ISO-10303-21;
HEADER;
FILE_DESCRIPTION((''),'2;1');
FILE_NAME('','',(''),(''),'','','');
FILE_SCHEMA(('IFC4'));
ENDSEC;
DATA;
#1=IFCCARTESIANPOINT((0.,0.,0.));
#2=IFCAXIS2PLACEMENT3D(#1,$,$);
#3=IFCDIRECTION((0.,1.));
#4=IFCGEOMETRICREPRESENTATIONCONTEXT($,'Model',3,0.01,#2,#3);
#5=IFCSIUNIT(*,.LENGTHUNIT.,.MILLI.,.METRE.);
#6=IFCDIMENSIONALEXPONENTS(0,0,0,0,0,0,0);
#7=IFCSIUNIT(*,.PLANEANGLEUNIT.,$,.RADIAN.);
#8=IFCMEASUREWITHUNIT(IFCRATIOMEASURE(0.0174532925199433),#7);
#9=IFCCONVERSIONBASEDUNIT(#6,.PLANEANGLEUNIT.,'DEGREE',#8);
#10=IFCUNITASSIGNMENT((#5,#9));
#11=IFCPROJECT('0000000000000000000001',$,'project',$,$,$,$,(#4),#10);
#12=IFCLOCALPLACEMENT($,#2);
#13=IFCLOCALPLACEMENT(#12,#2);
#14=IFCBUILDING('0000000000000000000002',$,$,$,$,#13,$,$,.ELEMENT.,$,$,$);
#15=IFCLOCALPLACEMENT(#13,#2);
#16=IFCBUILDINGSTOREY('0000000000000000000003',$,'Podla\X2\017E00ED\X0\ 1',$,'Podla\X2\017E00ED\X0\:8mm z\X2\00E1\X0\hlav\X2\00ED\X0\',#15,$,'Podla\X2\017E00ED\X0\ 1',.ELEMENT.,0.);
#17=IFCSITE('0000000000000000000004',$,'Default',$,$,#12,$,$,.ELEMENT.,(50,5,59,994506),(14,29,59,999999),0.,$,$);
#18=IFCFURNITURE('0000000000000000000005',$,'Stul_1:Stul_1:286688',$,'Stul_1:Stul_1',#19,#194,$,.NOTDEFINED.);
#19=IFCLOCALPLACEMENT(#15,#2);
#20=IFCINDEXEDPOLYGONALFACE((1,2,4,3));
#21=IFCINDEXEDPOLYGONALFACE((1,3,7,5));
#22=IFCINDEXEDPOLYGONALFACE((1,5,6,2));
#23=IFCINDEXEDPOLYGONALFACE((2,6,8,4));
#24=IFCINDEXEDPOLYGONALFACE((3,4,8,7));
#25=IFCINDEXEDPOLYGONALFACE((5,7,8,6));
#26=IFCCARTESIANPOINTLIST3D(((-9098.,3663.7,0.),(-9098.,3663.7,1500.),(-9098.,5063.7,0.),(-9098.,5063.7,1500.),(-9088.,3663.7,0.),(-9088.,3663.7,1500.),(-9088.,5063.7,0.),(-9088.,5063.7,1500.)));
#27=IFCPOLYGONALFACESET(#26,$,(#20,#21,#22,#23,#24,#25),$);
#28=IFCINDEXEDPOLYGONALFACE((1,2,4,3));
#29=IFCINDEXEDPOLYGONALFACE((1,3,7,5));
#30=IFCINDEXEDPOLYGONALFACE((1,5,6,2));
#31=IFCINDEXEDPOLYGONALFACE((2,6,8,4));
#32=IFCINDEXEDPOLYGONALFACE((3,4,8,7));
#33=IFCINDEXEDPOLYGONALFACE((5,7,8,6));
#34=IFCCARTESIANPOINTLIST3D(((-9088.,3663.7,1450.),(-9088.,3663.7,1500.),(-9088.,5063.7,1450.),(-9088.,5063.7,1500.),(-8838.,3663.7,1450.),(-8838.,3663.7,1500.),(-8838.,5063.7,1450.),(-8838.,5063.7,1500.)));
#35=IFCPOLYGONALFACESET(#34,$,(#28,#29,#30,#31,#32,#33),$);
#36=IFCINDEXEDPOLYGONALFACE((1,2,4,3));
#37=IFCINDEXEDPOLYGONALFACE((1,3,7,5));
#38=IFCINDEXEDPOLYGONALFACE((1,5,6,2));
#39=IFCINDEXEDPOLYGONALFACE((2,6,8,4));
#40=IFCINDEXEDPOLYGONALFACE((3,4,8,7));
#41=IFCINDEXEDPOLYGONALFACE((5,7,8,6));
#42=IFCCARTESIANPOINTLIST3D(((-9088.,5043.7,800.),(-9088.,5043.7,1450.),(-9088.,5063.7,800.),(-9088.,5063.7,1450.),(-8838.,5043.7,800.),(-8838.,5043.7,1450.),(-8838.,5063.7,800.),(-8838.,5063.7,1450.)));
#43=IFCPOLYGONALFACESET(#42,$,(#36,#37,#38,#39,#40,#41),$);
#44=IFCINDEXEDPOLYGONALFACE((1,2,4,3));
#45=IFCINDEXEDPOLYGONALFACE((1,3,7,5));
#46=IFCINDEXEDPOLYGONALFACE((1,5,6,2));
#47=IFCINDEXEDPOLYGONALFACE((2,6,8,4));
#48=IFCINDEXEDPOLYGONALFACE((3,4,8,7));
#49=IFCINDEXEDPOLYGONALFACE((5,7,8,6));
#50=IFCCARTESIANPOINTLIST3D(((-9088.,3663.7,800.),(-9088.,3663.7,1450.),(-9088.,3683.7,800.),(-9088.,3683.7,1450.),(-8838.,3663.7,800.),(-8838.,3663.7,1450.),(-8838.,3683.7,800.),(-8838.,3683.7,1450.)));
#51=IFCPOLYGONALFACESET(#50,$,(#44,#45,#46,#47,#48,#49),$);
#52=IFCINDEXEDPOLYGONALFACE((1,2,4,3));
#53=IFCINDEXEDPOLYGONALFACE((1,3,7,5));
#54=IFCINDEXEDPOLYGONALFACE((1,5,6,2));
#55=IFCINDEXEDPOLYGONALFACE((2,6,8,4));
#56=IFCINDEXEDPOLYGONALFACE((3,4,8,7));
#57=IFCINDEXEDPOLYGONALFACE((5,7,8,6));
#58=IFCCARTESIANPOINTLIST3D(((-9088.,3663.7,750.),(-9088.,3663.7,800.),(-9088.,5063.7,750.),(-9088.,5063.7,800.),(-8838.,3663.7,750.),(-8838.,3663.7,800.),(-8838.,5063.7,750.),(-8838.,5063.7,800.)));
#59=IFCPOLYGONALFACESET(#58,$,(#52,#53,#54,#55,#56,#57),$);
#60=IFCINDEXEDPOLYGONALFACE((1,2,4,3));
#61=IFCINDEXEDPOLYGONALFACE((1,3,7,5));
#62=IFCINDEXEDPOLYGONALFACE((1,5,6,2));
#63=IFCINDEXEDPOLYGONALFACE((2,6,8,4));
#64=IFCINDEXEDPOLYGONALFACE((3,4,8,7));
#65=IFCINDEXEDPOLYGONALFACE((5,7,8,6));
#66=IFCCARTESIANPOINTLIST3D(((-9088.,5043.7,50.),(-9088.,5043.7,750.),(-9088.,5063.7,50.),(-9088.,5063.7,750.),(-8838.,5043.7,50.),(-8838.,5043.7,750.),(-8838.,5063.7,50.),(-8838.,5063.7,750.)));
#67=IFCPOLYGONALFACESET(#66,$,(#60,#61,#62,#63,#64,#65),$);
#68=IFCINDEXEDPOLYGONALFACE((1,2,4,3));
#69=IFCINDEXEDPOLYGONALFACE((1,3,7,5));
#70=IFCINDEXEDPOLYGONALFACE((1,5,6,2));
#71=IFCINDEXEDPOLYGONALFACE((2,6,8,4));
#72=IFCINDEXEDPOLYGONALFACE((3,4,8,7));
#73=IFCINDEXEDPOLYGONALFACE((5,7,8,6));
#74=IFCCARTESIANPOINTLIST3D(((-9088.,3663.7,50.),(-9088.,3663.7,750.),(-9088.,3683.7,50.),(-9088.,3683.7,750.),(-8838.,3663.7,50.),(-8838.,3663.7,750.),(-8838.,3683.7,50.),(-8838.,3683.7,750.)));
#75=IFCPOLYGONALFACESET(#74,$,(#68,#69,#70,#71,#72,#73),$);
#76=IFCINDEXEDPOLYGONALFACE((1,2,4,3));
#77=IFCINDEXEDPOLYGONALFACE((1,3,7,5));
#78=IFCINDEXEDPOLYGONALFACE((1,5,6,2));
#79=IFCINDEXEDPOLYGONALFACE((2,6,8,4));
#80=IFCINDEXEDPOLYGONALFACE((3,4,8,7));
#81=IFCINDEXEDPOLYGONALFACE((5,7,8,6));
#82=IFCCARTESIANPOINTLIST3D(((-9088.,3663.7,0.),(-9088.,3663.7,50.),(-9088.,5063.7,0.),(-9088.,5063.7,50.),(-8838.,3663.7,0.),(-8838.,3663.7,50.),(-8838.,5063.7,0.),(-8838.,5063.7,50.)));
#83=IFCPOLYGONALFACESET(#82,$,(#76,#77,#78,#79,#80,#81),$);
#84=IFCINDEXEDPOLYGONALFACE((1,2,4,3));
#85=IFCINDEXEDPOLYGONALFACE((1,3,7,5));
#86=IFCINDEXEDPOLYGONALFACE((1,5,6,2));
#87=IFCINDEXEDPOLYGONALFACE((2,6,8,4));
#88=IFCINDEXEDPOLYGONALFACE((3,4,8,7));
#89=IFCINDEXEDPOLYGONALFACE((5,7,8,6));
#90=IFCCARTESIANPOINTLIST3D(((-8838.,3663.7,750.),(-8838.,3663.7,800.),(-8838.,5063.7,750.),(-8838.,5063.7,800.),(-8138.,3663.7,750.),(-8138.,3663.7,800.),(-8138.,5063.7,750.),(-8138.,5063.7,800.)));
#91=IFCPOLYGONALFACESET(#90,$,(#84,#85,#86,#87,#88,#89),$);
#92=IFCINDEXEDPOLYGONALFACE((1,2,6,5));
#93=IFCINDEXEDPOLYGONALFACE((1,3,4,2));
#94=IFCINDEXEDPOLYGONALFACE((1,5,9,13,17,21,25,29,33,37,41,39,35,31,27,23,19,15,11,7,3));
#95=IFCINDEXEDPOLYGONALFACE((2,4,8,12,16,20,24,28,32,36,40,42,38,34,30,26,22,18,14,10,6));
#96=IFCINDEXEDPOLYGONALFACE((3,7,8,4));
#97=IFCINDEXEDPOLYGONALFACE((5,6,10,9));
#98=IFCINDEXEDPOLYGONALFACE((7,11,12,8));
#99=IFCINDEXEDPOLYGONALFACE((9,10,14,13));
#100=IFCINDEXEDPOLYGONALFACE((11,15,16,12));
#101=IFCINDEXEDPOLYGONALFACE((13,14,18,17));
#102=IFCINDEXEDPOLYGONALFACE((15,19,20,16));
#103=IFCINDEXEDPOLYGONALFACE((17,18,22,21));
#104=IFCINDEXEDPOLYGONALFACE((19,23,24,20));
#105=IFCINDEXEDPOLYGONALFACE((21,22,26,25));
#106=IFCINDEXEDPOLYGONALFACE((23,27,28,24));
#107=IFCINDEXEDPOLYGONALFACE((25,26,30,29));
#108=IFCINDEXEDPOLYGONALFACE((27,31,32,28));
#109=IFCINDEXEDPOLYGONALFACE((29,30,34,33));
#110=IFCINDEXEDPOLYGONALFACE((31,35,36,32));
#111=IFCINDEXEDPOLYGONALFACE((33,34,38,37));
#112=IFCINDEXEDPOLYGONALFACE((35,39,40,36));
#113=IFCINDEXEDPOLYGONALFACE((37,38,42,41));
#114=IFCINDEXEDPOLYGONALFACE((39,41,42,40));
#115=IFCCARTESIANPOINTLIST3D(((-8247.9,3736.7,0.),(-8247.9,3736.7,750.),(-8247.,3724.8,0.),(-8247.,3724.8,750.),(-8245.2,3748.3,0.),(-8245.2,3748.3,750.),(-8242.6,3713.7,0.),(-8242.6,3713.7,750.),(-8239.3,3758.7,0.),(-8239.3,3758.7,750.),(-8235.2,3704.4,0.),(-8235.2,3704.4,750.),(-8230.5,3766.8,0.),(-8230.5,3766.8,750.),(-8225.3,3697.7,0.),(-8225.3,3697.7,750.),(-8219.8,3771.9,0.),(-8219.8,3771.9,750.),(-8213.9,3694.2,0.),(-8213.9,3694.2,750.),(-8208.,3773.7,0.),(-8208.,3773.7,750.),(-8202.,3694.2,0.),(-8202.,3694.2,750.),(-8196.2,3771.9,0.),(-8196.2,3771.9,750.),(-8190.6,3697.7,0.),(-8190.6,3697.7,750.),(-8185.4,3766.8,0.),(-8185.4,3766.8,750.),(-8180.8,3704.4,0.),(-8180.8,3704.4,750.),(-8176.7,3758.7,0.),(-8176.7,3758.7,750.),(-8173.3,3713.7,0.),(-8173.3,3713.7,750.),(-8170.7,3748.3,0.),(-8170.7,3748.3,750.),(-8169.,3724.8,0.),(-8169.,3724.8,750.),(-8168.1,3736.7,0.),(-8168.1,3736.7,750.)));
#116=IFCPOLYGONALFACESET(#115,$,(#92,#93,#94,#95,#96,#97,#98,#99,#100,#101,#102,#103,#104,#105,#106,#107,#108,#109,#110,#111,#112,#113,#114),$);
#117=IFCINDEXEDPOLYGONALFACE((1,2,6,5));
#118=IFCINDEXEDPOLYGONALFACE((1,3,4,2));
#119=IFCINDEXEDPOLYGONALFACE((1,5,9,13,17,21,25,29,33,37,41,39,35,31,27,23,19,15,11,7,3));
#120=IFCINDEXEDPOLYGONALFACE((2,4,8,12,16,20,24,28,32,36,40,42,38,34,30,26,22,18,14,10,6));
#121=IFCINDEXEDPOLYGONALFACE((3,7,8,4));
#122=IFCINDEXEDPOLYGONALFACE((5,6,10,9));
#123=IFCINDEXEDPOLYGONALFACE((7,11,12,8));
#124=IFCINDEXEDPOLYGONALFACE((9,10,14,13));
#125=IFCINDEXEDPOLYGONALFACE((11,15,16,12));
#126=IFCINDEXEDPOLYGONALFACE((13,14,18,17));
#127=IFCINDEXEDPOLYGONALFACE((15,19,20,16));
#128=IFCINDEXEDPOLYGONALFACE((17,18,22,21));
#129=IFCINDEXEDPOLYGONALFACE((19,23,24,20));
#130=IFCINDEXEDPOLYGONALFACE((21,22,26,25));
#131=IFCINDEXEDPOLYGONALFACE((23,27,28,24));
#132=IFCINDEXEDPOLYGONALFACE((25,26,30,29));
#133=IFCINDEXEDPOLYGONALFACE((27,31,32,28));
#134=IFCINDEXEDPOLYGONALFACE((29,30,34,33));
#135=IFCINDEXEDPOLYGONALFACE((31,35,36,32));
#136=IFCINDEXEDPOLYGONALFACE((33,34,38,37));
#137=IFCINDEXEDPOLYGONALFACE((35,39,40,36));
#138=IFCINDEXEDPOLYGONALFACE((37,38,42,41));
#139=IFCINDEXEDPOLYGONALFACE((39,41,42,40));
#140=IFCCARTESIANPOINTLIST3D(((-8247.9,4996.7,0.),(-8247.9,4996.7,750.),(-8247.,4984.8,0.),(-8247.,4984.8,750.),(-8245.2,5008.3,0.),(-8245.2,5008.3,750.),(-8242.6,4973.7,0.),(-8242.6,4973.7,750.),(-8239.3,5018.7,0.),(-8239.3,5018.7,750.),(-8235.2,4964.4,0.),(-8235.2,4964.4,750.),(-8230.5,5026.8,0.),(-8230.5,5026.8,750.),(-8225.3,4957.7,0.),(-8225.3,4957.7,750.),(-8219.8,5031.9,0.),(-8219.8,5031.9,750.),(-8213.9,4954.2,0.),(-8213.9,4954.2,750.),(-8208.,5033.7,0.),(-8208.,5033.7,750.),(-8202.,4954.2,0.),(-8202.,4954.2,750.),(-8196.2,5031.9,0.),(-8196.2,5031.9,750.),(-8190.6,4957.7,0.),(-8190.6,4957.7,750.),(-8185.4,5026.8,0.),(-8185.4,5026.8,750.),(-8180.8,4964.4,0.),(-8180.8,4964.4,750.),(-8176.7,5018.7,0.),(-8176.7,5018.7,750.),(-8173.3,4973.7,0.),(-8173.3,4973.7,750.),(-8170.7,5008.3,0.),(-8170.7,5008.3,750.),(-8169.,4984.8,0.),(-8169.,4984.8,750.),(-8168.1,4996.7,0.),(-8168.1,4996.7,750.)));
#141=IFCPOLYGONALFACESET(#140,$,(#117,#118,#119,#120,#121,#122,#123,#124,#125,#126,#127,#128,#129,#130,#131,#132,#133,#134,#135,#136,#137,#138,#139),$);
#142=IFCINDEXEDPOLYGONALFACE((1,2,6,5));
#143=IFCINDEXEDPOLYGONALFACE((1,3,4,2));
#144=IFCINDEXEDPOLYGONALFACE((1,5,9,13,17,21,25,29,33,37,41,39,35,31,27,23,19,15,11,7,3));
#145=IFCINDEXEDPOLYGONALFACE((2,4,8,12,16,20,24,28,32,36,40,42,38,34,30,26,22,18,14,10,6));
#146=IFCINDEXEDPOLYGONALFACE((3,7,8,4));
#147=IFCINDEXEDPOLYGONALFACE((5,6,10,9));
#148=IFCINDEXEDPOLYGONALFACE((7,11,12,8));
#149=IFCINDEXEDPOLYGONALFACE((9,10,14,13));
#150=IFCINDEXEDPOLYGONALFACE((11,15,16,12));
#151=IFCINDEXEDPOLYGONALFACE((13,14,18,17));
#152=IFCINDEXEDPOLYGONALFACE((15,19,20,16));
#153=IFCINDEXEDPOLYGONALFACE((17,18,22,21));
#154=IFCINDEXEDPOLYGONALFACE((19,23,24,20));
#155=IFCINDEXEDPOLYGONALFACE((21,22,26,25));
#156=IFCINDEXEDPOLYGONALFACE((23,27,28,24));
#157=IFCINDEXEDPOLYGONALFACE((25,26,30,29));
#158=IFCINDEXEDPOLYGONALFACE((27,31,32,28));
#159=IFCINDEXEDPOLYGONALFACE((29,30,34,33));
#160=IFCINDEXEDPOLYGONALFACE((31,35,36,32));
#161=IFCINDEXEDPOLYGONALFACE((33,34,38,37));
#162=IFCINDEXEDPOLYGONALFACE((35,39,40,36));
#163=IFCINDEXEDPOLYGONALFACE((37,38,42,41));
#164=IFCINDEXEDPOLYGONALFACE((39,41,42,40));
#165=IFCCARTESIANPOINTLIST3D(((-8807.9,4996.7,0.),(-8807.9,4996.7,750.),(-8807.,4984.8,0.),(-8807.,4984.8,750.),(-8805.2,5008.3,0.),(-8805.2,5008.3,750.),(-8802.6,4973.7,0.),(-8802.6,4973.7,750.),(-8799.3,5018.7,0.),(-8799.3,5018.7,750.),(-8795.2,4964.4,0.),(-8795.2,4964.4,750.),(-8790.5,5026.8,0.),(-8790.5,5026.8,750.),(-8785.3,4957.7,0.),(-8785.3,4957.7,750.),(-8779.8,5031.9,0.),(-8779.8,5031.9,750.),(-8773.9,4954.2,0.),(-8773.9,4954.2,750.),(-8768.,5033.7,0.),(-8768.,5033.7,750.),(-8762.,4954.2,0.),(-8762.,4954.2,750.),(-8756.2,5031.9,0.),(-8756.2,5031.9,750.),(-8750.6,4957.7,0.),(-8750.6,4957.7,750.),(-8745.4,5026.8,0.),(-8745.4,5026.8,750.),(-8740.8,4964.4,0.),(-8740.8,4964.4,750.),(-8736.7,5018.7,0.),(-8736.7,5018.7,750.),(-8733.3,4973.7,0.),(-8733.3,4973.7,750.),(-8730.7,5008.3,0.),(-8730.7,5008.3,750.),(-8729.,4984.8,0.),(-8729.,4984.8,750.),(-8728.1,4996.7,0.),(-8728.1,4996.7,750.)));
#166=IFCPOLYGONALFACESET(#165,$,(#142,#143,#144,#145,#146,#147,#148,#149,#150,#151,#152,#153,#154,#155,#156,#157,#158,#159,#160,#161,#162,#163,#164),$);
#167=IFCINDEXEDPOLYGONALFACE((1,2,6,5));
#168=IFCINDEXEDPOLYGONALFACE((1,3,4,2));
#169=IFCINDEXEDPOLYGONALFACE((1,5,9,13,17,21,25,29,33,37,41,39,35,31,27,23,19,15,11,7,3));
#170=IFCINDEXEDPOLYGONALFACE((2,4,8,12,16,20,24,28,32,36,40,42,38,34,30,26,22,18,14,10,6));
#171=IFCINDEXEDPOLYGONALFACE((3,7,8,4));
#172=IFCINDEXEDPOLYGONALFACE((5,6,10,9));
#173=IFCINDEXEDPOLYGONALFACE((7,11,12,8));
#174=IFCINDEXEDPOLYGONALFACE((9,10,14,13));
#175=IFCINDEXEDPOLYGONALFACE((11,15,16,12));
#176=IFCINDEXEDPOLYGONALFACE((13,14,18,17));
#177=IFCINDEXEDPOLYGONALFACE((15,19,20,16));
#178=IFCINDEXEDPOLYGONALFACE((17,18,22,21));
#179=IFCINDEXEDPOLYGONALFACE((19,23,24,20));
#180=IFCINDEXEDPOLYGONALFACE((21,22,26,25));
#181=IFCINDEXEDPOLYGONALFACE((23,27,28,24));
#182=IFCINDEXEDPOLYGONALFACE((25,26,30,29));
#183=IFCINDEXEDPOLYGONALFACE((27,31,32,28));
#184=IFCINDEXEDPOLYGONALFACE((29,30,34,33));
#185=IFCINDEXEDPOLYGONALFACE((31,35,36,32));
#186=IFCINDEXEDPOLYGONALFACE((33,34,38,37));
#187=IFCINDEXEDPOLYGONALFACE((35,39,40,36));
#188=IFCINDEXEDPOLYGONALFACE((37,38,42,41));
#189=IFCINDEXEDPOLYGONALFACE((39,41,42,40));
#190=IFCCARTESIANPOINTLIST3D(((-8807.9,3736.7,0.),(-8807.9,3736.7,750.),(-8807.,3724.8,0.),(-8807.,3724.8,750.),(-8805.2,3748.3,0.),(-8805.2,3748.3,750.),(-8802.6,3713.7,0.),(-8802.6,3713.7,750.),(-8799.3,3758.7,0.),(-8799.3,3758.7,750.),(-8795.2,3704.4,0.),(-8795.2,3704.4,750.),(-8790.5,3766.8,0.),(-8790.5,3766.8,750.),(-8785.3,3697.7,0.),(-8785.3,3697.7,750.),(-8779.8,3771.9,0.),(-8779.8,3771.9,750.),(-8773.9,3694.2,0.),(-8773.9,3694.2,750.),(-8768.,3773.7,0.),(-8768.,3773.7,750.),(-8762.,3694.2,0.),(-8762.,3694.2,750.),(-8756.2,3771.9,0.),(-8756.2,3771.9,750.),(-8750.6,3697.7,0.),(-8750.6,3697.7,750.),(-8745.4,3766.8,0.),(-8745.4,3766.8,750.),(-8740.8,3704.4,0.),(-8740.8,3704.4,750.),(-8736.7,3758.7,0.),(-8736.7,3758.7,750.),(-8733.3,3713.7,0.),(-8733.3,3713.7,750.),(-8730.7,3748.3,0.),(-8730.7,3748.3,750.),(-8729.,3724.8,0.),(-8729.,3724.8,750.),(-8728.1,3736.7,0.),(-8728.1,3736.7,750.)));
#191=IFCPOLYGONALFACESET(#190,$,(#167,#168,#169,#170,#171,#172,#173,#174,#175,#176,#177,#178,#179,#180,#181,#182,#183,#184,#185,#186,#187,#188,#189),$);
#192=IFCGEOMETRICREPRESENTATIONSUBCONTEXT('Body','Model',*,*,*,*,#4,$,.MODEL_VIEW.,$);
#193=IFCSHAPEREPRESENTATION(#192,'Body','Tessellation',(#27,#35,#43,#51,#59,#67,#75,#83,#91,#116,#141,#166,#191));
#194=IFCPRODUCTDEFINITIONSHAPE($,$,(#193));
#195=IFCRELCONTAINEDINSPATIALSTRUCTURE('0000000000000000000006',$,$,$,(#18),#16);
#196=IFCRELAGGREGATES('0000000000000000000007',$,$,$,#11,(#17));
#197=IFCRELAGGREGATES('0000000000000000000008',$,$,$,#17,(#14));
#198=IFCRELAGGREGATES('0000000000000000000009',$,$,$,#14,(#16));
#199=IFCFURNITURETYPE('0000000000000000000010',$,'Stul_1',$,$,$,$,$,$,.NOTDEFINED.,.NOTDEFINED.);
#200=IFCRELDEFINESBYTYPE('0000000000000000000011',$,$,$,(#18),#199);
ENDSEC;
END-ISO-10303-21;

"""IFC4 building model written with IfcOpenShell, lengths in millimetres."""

from ifc_helpers import new_model, entity, si_unit, converted_unit, direction, frame, frame_2d, origin, origin_2d_with_axis, place, context, subcontext, project, spatial, rectangle, circle, extrude, source, transform, mapped, type_object, type_shapes, element, save


model = new_model("IFC4")

# Units and contexts
model_context = context("Model", 3, precision=0.01, world=origin(), true_north=direction((0.0, 1.0)))
body_context = subcontext(model_context, "Body", "Model", "MODEL_VIEW")
ifc_project = project(units=[si_unit("LENGTHUNIT", "METRE", prefix="MILLI"), converted_unit("PLANEANGLEUNIT", "DEGREE", entity("IfcRatioMeasure", 0.0174532925199433), si_unit("PLANEANGLEUNIT", "RADIAN"), dimensions=[0, 0, 0, 0, 0, 0, 0])], contexts=[model_context])

# Site, building, storey
site_placement = place(None, origin())
site = spatial("IfcSite", under=ifc_project, at=site_placement, Name="Default", CompositionType="ELEMENT", RefLatitude=(50, 5, 59, 994506), RefLongitude=(14, 29, 59, 999999), RefElevation=0.0)
building_placement = place(site_placement, origin())
building = spatial("IfcBuilding", under=site, at=building_placement, CompositionType="ELEMENT")
storey_placement = place(building_placement, origin())
storey = spatial("IfcBuildingStorey", under=building, at=storey_placement, Name="Podlaží 1", ObjectType="Podlaží:8mm záhlaví", LongName="Podlaží 1", CompositionType="ELEMENT", Elevation=0.0)

# Furniture
furniture_type = type_object("IfcFurnitureType", Name="Stul_1", AssemblyPlace="NOTDEFINED", PredefinedType="NOTDEFINED")
shared_shape_1 = source(origin(), body_context, "Body", "SweptSolid", [
    extrude(rectangle(XDim=1400.0, YDim=10.0, at=origin_2d_with_axis()), frame((0.0, 605.0, 0.0), z_axis=(0.0, 0.0, 1.0), x_axis=(-1.0, 0.0, 0.0)), (0.0, 0.0, 1.0), 1500.0),
    extrude(rectangle(XDim=1400.0, YDim=250.0, at=frame_2d((0.0, 0.0), x_axis=(1.0, 0.0))), frame((0.0, 475.0, 1450.0), z_axis=(0.0, 0.0, 1.0), x_axis=(-1.0, 0.0, 0.0)), (0.0, 0.0, 1.0), 50.0),
    extrude(rectangle(XDim=20.0, YDim=250.0, at=origin_2d_with_axis()), frame((690.0, 475.0, 800.0), z_axis=(0.0, 0.0, 1.0), x_axis=(-1.0, 0.0, 0.0)), (0.0, 0.0, 1.0), 650.0),
    extrude(rectangle(XDim=20.0, YDim=250.0, at=frame_2d((0.0, 0.0), x_axis=(1.0, 0.0))), frame((-690.0, 475.0, 800.0), z_axis=(0.0, 0.0, 1.0), x_axis=(-1.0, 0.0, 0.0)), (0.0, 0.0, 1.0), 650.0),
    extrude(rectangle(XDim=1400.0, YDim=250.0, at=origin_2d_with_axis()), frame((0.0, 475.0, 750.0), z_axis=(0.0, 0.0, 1.0), x_axis=(-1.0, 0.0, 0.0)), (0.0, 0.0, 1.0), 50.0),
    extrude(rectangle(XDim=20.0, YDim=250.0, at=origin_2d_with_axis()), frame((690.0, 475.0, 50.0), z_axis=(0.0, 0.0, 1.0), x_axis=(-1.0, 0.0, 0.0)), (0.0, 0.0, 1.0), 700.0),
    extrude(rectangle(XDim=20.0, YDim=250.0, at=frame_2d((0.0, 0.0), x_axis=(1.0, 0.0))), frame((-690.0, 475.0, 50.0), z_axis=(0.0, 0.0, 1.0), x_axis=(-1.0, 0.0, 0.0)), (0.0, 0.0, 1.0), 700.0),
    extrude(rectangle(XDim=1400.0, YDim=250.0, at=origin_2d_with_axis()), frame((0.0, 475.0, 0.0), z_axis=(0.0, 0.0, 1.0), x_axis=(-1.0, 0.0, 0.0)), (0.0, 0.0, 1.0), 50.0),
    extrude(rectangle(XDim=1400.0, YDim=700.0, at=origin_2d_with_axis()), frame((0.0, 0.0, 750.0), z_axis=(0.0, 0.0, 1.0), x_axis=(-1.0, 0.0, 0.0)), (0.0, 0.0, 1.0), 50.0),
    extrude(circle(Radius=40.0, at=frame_2d((0.0, 0.0), x_axis=(1.0, 0.0))), frame((-630.0, -280.0, 0.0)), (0.0, 0.0, 1.0), 750.0),
    extrude(circle(Radius=40.0, at=frame_2d((0.0, 0.0), x_axis=(1.0, 0.0))), frame((630.0, -280.0, 0.0)), (0.0, 0.0, 1.0), 750.0),
    extrude(circle(Radius=40.0, at=frame_2d((0.0, 0.0), x_axis=(1.0, 0.0))), frame((630.0, 280.0, 0.0)), (0.0, 0.0, 1.0), 750.0),
    extrude(circle(Radius=40.0, at=frame_2d((0.0, 0.0), x_axis=(1.0, 0.0))), frame((-630.0, 280.0, 0.0)), (0.0, 0.0, 1.0), 750.0),
])
type_shapes(furniture_type, [shared_shape_1])
for number, where, z_axis, x_axis, name in (
    (1, (-8488.0, 4363.7, 0.0), (0.0, 0.0, 1.0), (0.0, 1.0, 0.0), "Stul_1:Stul_1:286688"),
):
    element("IfcFurniture", number, at=place(storey_placement, frame(where, z_axis=z_axis, x_axis=x_axis)), inside=storey, type_object=furniture_type, Name=name, ObjectType="Stul_1:Stul_1", PredefinedType="NOTDEFINED", context=body_context, shape_type="MappedRepresentation", body=[
        mapped(shared_shape_1, transform((0.0, 0.0, 0.0), scale=1.0)),
    ])

save(model, "model.ifc")
